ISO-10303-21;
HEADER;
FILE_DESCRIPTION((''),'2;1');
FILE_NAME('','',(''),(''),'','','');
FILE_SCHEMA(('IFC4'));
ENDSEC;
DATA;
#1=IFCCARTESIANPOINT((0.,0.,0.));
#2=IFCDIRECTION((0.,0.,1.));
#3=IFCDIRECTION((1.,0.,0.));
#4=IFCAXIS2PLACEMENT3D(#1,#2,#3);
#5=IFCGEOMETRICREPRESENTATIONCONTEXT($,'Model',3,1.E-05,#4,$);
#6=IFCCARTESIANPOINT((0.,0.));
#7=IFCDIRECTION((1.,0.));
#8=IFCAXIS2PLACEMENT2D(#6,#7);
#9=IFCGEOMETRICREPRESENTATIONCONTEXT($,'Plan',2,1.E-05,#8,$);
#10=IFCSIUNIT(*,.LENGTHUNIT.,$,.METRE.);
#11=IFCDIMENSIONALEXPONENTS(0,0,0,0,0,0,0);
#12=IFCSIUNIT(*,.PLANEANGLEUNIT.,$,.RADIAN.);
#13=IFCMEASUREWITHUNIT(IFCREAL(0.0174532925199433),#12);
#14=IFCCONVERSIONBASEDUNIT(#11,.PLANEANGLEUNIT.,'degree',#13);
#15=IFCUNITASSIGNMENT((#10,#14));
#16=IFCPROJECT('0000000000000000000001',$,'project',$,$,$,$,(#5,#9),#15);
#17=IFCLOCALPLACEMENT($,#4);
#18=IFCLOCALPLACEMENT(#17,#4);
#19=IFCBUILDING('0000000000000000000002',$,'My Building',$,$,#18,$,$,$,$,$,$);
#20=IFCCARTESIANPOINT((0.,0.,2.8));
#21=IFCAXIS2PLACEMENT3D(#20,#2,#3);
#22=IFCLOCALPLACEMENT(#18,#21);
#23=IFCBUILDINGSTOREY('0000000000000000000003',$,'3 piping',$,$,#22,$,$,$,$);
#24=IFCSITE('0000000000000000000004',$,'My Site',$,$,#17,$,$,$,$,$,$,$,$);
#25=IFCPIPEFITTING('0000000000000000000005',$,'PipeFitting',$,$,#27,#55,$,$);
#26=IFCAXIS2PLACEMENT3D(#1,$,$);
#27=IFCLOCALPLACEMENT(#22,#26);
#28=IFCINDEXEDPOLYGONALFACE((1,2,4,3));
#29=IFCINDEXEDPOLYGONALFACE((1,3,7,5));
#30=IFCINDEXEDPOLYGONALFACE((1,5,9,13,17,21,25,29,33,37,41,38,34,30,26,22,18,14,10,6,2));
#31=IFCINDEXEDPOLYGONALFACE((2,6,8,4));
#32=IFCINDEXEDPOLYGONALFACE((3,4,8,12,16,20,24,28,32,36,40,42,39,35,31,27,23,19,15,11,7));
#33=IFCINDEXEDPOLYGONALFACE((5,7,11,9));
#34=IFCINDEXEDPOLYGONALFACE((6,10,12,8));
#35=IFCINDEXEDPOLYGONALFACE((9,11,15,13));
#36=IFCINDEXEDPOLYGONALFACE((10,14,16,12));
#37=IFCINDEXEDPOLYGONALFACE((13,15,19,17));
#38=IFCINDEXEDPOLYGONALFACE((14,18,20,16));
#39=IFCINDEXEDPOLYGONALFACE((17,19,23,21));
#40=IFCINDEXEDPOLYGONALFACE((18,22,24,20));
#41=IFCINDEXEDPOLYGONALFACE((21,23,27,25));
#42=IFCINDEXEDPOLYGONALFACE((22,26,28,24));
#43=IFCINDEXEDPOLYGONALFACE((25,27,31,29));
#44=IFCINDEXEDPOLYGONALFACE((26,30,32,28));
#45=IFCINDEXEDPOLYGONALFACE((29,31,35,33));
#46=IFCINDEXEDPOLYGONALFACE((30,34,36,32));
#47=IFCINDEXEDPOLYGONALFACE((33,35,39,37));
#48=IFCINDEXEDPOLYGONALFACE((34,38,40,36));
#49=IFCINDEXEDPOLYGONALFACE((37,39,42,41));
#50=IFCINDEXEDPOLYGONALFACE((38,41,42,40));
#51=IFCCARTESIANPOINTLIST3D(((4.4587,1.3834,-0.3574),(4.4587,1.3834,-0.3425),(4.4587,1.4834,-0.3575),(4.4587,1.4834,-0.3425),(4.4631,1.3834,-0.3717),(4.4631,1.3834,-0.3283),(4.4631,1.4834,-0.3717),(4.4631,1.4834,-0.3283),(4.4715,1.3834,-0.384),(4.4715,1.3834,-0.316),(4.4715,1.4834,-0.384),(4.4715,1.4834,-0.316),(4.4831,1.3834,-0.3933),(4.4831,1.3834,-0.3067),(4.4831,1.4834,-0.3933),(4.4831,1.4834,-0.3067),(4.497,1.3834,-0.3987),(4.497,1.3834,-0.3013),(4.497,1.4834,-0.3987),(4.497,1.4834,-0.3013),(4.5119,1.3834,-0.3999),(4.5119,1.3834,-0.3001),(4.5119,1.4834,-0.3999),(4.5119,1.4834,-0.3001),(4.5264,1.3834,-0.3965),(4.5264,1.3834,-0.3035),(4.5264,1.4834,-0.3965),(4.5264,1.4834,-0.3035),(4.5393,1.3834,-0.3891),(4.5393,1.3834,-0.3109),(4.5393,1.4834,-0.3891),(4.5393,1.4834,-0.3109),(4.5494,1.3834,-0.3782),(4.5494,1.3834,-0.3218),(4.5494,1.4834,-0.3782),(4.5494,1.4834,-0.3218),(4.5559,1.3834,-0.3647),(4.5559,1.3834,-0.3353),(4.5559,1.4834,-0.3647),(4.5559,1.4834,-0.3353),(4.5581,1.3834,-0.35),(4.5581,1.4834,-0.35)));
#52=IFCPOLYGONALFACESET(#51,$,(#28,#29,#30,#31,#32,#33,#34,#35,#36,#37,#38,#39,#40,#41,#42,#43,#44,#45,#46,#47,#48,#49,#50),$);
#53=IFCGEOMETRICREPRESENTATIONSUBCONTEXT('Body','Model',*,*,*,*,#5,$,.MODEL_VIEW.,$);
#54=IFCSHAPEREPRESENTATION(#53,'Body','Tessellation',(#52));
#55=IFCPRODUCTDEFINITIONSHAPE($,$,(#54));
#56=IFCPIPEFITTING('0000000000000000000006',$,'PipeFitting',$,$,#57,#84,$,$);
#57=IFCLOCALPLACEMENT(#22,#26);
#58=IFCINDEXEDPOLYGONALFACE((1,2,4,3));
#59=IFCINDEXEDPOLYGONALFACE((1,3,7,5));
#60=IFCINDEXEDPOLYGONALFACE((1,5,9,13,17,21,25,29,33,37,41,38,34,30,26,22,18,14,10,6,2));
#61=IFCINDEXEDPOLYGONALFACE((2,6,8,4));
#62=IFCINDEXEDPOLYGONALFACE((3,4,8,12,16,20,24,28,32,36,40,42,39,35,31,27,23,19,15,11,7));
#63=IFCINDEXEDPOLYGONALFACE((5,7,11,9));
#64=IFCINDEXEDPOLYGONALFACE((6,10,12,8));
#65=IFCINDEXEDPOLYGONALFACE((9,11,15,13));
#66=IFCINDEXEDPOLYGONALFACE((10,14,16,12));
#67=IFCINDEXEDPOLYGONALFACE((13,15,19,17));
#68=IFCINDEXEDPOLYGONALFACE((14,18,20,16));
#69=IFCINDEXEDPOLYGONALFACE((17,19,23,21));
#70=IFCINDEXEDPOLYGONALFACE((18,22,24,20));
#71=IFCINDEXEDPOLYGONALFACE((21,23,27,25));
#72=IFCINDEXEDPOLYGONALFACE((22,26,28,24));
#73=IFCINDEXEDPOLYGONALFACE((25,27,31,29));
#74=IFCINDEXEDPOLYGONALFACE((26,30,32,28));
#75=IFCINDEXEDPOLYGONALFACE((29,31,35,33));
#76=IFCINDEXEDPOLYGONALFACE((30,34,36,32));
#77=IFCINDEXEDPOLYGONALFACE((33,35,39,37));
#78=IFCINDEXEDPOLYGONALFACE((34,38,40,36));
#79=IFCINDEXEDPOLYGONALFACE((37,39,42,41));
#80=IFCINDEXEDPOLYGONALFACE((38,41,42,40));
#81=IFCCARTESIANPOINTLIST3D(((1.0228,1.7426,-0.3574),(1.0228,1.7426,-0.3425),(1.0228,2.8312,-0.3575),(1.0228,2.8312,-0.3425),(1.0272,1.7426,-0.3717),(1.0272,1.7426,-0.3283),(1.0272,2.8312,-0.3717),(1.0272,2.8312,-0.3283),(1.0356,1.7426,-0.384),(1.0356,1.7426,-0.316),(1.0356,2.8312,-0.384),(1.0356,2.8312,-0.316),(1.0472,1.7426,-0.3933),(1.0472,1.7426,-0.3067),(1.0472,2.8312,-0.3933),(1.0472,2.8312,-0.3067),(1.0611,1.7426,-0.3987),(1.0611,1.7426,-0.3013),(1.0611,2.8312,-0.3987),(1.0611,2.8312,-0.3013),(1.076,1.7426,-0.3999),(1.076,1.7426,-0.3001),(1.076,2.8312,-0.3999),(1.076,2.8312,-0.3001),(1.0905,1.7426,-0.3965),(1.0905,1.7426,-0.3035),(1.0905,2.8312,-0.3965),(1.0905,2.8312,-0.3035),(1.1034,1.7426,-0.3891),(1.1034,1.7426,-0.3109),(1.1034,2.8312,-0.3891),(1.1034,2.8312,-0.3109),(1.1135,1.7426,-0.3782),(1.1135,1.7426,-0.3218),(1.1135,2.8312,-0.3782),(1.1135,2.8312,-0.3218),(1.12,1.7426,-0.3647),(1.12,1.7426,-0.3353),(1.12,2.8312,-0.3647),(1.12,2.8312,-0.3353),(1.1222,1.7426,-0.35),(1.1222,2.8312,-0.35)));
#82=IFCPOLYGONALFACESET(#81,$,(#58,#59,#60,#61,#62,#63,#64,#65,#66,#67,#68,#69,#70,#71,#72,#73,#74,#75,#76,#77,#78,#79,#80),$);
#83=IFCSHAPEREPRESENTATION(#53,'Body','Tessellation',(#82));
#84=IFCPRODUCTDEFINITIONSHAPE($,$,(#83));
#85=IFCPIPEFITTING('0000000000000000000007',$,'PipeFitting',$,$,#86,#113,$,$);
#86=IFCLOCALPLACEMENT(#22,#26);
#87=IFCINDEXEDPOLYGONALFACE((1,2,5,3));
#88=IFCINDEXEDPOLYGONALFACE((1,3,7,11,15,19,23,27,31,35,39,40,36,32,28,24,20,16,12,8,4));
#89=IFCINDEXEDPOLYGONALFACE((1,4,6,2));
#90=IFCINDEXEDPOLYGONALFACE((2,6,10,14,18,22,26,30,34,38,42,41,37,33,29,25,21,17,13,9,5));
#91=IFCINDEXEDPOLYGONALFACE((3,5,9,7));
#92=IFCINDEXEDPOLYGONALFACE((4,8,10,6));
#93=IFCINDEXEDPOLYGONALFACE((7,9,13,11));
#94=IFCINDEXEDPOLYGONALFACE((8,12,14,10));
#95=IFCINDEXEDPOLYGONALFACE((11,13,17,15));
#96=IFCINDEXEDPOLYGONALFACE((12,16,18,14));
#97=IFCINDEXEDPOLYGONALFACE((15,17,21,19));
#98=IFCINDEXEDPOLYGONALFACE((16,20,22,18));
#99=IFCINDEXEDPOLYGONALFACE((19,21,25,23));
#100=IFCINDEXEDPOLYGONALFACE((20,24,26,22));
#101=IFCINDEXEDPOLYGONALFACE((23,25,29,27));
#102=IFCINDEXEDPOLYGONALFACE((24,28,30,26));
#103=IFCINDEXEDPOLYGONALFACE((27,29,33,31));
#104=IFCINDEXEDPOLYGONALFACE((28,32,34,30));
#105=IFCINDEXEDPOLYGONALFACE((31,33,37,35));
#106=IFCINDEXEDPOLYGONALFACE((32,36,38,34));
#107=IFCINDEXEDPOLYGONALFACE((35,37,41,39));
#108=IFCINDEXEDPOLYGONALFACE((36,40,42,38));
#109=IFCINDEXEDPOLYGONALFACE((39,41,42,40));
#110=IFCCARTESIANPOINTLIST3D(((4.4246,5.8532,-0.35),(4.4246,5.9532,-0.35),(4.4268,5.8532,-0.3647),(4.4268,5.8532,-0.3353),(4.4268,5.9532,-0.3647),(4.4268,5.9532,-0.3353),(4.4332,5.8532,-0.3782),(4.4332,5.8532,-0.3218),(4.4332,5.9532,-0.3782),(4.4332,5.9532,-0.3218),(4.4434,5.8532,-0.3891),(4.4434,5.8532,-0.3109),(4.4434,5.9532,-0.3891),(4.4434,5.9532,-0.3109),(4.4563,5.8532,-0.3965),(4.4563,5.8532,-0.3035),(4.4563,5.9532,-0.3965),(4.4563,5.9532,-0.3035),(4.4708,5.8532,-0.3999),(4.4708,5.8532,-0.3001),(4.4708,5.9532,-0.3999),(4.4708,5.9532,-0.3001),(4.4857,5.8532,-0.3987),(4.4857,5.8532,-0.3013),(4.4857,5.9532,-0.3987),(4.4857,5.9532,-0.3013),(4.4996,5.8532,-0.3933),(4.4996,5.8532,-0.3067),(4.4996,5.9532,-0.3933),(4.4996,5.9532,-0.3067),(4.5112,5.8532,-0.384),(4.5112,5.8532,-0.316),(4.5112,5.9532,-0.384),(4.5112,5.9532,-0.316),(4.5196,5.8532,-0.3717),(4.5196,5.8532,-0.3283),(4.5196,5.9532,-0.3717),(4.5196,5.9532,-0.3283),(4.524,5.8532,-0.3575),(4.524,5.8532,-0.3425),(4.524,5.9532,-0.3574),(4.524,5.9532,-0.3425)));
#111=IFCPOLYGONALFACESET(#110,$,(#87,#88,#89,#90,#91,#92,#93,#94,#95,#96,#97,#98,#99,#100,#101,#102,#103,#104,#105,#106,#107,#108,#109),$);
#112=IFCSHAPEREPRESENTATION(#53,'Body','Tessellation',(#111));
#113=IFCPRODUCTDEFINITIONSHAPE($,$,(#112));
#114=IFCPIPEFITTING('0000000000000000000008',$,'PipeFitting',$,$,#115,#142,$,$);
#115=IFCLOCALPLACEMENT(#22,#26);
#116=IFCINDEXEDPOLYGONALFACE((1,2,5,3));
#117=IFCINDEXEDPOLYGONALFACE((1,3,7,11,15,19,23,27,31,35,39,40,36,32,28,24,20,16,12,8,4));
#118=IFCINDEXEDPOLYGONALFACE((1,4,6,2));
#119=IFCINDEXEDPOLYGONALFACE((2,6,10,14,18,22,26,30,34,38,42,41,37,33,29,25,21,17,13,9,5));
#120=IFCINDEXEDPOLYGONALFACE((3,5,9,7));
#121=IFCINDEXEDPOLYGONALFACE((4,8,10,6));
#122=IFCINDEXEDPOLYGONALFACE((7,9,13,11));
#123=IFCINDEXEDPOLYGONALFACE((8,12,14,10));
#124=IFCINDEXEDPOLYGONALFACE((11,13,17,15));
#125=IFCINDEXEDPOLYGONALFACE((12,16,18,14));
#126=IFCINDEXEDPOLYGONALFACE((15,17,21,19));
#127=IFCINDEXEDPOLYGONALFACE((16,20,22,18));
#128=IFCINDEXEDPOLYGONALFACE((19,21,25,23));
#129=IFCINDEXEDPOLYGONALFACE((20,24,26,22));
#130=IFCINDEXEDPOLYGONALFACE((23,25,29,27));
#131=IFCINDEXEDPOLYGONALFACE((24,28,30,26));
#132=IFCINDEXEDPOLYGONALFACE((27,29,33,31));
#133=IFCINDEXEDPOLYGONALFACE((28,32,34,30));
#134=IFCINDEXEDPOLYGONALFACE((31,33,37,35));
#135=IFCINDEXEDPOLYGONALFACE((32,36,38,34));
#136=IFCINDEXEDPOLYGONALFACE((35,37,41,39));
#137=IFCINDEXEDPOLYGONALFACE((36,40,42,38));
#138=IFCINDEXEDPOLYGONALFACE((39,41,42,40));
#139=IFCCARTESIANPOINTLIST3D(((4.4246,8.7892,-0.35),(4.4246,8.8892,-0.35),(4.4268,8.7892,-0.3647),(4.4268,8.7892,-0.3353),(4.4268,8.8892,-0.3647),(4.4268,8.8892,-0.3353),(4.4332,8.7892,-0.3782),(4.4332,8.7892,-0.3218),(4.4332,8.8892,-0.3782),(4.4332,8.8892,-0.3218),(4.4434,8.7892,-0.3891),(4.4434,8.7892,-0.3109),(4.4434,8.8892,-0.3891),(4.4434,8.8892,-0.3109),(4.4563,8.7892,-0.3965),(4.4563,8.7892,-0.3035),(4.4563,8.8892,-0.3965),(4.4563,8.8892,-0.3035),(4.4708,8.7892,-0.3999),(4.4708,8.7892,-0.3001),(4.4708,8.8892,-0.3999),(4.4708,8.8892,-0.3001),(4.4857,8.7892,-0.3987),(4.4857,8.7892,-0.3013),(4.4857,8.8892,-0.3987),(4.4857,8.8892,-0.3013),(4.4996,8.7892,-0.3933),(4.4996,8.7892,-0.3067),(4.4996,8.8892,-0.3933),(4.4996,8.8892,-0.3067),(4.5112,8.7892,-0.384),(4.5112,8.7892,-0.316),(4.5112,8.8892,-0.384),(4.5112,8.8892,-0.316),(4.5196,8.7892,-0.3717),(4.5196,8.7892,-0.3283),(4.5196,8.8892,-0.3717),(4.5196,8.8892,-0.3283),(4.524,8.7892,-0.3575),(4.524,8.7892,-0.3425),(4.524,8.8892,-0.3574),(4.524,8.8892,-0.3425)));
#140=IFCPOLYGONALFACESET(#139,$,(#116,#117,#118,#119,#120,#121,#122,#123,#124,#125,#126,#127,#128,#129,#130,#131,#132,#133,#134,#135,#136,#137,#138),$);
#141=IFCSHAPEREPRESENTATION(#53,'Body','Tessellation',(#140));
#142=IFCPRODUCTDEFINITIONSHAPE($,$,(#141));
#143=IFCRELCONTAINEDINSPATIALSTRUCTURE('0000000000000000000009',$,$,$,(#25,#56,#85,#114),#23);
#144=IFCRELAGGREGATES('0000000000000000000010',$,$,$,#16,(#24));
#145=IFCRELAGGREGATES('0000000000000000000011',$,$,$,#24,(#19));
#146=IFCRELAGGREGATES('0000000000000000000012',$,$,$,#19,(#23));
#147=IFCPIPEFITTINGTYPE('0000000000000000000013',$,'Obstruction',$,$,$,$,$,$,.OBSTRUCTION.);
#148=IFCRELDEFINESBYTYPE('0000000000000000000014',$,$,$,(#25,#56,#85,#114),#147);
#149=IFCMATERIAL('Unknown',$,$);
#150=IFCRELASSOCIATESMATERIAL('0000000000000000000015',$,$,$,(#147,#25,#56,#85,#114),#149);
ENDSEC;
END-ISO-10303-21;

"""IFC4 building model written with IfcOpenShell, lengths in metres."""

from ifc_helpers import new_model, entity, si_unit, converted_unit, frame, origin_with_axes, origin_2d_with_axis, place, context, subcontext, project, spatial, circle, extrude, material, material_profile, profile_set, profile_usage, type_object, element, save


model = new_model("IFC4")

# Units and contexts
model_context = context("Model", 3, precision=1e-05, world=origin_with_axes())
plan_context = context("Plan", 2, precision=1e-05, world=origin_2d_with_axis())
body_context = subcontext(model_context, "Body", "Model", "MODEL_VIEW")
ifc_project = project(units=[si_unit("LENGTHUNIT", "METRE"), converted_unit("PLANEANGLEUNIT", "degree", entity("IfcReal", 0.0174532925199433), si_unit("PLANEANGLEUNIT", "RADIAN"), dimensions=[0, 0, 0, 0, 0, 0, 0])], contexts=[model_context, plan_context])

# Site, building, storey
site_placement = place(None, origin_with_axes())
site = spatial("IfcSite", under=ifc_project, at=site_placement, Name="My Site")
building_placement = place(site_placement, origin_with_axes())
building = spatial("IfcBuilding", under=site, at=building_placement, Name="My Building")
storey_placement = place(building_placement, frame((0.0, 0.0, 2.8), z_axis=(0.0, 0.0, 1.0), x_axis=(1.0, 0.0, 0.0)))
storey = spatial("IfcBuildingStorey", under=building, at=storey_placement, Name="3 piping")

# Shared definitions
ifc_material = material(Name="Unknown")

# Pipe fittings
ifc_material_profile_1 = material_profile(ifc_material, circle(Radius=0.05))
ifc_profile_set_1 = profile_set([ifc_material_profile_1])
ifc_profile_usage_1 = profile_usage(ifc_profile_set_1, cardinal=5)
pipe_fitting_type_1 = type_object("IfcPipeFittingType", Name="Obstruction", PredefinedType="OBSTRUCTION", material=ifc_profile_set_1)
pipe_fitting_1_placement = place(storey_placement, frame((4.5081, 1.4834, -0.35), z_axis=(0.0, -1.0, 0.000025), x_axis=(1.0, 0.0, 0.0)))
element("IfcPipeFitting", 1, at=pipe_fitting_1_placement, inside=storey, type_object=pipe_fitting_type_1, material=ifc_profile_usage_1, Name="PipeFitting", context=body_context, shape_type="SweptSolid", body=[
    extrude(circle(Radius=0.05), origin_with_axes(), (0.0, 0.0, 1.0), 0.1),
])
ifc_profile_usage_2 = profile_usage(ifc_profile_set_1, cardinal=5)
pipe_fitting_2_placement = place(storey_placement, frame((1.0722, 2.8312, -0.35), z_axis=(0.0, -1.0, 0.000002), x_axis=(1.0, 0.0, 0.0)))
element("IfcPipeFitting", 2, at=pipe_fitting_2_placement, inside=storey, type_object=pipe_fitting_type_1, material=ifc_profile_usage_2, Name="PipeFitting", context=body_context, shape_type="SweptSolid", body=[
    extrude(circle(Radius=0.05), origin_with_axes(), (0.0, 0.0, 1.0), 1.0886),
])
ifc_profile_usage_3 = profile_usage(ifc_profile_set_1, cardinal=5)
pipe_fitting_3_placement = place(storey_placement, frame((4.4746, 5.8532, -0.35), z_axis=(0.0, 1.0, 0.000025), x_axis=(-1.0, 0.0, 0.0)))
element("IfcPipeFitting", 3, at=pipe_fitting_3_placement, inside=storey, type_object=pipe_fitting_type_1, material=ifc_profile_usage_3, Name="PipeFitting", context=body_context, shape_type="SweptSolid", body=[
    extrude(circle(Radius=0.05), origin_with_axes(), (0.0, 0.0, 1.0), 0.1),
])
ifc_profile_usage_4 = profile_usage(ifc_profile_set_1, cardinal=5)
pipe_fitting_4_placement = place(storey_placement, frame((4.4746, 8.7892, -0.35), z_axis=(0.0, 1.0, 0.000025), x_axis=(-1.0, 0.0, 0.0)))
element("IfcPipeFitting", 4, at=pipe_fitting_4_placement, inside=storey, type_object=pipe_fitting_type_1, material=ifc_profile_usage_4, Name="PipeFitting", context=body_context, shape_type="SweptSolid", body=[
    extrude(circle(Radius=0.05), origin_with_axes(), (0.0, 0.0, 1.0), 0.1),
])

save(model, "model.ifc")
